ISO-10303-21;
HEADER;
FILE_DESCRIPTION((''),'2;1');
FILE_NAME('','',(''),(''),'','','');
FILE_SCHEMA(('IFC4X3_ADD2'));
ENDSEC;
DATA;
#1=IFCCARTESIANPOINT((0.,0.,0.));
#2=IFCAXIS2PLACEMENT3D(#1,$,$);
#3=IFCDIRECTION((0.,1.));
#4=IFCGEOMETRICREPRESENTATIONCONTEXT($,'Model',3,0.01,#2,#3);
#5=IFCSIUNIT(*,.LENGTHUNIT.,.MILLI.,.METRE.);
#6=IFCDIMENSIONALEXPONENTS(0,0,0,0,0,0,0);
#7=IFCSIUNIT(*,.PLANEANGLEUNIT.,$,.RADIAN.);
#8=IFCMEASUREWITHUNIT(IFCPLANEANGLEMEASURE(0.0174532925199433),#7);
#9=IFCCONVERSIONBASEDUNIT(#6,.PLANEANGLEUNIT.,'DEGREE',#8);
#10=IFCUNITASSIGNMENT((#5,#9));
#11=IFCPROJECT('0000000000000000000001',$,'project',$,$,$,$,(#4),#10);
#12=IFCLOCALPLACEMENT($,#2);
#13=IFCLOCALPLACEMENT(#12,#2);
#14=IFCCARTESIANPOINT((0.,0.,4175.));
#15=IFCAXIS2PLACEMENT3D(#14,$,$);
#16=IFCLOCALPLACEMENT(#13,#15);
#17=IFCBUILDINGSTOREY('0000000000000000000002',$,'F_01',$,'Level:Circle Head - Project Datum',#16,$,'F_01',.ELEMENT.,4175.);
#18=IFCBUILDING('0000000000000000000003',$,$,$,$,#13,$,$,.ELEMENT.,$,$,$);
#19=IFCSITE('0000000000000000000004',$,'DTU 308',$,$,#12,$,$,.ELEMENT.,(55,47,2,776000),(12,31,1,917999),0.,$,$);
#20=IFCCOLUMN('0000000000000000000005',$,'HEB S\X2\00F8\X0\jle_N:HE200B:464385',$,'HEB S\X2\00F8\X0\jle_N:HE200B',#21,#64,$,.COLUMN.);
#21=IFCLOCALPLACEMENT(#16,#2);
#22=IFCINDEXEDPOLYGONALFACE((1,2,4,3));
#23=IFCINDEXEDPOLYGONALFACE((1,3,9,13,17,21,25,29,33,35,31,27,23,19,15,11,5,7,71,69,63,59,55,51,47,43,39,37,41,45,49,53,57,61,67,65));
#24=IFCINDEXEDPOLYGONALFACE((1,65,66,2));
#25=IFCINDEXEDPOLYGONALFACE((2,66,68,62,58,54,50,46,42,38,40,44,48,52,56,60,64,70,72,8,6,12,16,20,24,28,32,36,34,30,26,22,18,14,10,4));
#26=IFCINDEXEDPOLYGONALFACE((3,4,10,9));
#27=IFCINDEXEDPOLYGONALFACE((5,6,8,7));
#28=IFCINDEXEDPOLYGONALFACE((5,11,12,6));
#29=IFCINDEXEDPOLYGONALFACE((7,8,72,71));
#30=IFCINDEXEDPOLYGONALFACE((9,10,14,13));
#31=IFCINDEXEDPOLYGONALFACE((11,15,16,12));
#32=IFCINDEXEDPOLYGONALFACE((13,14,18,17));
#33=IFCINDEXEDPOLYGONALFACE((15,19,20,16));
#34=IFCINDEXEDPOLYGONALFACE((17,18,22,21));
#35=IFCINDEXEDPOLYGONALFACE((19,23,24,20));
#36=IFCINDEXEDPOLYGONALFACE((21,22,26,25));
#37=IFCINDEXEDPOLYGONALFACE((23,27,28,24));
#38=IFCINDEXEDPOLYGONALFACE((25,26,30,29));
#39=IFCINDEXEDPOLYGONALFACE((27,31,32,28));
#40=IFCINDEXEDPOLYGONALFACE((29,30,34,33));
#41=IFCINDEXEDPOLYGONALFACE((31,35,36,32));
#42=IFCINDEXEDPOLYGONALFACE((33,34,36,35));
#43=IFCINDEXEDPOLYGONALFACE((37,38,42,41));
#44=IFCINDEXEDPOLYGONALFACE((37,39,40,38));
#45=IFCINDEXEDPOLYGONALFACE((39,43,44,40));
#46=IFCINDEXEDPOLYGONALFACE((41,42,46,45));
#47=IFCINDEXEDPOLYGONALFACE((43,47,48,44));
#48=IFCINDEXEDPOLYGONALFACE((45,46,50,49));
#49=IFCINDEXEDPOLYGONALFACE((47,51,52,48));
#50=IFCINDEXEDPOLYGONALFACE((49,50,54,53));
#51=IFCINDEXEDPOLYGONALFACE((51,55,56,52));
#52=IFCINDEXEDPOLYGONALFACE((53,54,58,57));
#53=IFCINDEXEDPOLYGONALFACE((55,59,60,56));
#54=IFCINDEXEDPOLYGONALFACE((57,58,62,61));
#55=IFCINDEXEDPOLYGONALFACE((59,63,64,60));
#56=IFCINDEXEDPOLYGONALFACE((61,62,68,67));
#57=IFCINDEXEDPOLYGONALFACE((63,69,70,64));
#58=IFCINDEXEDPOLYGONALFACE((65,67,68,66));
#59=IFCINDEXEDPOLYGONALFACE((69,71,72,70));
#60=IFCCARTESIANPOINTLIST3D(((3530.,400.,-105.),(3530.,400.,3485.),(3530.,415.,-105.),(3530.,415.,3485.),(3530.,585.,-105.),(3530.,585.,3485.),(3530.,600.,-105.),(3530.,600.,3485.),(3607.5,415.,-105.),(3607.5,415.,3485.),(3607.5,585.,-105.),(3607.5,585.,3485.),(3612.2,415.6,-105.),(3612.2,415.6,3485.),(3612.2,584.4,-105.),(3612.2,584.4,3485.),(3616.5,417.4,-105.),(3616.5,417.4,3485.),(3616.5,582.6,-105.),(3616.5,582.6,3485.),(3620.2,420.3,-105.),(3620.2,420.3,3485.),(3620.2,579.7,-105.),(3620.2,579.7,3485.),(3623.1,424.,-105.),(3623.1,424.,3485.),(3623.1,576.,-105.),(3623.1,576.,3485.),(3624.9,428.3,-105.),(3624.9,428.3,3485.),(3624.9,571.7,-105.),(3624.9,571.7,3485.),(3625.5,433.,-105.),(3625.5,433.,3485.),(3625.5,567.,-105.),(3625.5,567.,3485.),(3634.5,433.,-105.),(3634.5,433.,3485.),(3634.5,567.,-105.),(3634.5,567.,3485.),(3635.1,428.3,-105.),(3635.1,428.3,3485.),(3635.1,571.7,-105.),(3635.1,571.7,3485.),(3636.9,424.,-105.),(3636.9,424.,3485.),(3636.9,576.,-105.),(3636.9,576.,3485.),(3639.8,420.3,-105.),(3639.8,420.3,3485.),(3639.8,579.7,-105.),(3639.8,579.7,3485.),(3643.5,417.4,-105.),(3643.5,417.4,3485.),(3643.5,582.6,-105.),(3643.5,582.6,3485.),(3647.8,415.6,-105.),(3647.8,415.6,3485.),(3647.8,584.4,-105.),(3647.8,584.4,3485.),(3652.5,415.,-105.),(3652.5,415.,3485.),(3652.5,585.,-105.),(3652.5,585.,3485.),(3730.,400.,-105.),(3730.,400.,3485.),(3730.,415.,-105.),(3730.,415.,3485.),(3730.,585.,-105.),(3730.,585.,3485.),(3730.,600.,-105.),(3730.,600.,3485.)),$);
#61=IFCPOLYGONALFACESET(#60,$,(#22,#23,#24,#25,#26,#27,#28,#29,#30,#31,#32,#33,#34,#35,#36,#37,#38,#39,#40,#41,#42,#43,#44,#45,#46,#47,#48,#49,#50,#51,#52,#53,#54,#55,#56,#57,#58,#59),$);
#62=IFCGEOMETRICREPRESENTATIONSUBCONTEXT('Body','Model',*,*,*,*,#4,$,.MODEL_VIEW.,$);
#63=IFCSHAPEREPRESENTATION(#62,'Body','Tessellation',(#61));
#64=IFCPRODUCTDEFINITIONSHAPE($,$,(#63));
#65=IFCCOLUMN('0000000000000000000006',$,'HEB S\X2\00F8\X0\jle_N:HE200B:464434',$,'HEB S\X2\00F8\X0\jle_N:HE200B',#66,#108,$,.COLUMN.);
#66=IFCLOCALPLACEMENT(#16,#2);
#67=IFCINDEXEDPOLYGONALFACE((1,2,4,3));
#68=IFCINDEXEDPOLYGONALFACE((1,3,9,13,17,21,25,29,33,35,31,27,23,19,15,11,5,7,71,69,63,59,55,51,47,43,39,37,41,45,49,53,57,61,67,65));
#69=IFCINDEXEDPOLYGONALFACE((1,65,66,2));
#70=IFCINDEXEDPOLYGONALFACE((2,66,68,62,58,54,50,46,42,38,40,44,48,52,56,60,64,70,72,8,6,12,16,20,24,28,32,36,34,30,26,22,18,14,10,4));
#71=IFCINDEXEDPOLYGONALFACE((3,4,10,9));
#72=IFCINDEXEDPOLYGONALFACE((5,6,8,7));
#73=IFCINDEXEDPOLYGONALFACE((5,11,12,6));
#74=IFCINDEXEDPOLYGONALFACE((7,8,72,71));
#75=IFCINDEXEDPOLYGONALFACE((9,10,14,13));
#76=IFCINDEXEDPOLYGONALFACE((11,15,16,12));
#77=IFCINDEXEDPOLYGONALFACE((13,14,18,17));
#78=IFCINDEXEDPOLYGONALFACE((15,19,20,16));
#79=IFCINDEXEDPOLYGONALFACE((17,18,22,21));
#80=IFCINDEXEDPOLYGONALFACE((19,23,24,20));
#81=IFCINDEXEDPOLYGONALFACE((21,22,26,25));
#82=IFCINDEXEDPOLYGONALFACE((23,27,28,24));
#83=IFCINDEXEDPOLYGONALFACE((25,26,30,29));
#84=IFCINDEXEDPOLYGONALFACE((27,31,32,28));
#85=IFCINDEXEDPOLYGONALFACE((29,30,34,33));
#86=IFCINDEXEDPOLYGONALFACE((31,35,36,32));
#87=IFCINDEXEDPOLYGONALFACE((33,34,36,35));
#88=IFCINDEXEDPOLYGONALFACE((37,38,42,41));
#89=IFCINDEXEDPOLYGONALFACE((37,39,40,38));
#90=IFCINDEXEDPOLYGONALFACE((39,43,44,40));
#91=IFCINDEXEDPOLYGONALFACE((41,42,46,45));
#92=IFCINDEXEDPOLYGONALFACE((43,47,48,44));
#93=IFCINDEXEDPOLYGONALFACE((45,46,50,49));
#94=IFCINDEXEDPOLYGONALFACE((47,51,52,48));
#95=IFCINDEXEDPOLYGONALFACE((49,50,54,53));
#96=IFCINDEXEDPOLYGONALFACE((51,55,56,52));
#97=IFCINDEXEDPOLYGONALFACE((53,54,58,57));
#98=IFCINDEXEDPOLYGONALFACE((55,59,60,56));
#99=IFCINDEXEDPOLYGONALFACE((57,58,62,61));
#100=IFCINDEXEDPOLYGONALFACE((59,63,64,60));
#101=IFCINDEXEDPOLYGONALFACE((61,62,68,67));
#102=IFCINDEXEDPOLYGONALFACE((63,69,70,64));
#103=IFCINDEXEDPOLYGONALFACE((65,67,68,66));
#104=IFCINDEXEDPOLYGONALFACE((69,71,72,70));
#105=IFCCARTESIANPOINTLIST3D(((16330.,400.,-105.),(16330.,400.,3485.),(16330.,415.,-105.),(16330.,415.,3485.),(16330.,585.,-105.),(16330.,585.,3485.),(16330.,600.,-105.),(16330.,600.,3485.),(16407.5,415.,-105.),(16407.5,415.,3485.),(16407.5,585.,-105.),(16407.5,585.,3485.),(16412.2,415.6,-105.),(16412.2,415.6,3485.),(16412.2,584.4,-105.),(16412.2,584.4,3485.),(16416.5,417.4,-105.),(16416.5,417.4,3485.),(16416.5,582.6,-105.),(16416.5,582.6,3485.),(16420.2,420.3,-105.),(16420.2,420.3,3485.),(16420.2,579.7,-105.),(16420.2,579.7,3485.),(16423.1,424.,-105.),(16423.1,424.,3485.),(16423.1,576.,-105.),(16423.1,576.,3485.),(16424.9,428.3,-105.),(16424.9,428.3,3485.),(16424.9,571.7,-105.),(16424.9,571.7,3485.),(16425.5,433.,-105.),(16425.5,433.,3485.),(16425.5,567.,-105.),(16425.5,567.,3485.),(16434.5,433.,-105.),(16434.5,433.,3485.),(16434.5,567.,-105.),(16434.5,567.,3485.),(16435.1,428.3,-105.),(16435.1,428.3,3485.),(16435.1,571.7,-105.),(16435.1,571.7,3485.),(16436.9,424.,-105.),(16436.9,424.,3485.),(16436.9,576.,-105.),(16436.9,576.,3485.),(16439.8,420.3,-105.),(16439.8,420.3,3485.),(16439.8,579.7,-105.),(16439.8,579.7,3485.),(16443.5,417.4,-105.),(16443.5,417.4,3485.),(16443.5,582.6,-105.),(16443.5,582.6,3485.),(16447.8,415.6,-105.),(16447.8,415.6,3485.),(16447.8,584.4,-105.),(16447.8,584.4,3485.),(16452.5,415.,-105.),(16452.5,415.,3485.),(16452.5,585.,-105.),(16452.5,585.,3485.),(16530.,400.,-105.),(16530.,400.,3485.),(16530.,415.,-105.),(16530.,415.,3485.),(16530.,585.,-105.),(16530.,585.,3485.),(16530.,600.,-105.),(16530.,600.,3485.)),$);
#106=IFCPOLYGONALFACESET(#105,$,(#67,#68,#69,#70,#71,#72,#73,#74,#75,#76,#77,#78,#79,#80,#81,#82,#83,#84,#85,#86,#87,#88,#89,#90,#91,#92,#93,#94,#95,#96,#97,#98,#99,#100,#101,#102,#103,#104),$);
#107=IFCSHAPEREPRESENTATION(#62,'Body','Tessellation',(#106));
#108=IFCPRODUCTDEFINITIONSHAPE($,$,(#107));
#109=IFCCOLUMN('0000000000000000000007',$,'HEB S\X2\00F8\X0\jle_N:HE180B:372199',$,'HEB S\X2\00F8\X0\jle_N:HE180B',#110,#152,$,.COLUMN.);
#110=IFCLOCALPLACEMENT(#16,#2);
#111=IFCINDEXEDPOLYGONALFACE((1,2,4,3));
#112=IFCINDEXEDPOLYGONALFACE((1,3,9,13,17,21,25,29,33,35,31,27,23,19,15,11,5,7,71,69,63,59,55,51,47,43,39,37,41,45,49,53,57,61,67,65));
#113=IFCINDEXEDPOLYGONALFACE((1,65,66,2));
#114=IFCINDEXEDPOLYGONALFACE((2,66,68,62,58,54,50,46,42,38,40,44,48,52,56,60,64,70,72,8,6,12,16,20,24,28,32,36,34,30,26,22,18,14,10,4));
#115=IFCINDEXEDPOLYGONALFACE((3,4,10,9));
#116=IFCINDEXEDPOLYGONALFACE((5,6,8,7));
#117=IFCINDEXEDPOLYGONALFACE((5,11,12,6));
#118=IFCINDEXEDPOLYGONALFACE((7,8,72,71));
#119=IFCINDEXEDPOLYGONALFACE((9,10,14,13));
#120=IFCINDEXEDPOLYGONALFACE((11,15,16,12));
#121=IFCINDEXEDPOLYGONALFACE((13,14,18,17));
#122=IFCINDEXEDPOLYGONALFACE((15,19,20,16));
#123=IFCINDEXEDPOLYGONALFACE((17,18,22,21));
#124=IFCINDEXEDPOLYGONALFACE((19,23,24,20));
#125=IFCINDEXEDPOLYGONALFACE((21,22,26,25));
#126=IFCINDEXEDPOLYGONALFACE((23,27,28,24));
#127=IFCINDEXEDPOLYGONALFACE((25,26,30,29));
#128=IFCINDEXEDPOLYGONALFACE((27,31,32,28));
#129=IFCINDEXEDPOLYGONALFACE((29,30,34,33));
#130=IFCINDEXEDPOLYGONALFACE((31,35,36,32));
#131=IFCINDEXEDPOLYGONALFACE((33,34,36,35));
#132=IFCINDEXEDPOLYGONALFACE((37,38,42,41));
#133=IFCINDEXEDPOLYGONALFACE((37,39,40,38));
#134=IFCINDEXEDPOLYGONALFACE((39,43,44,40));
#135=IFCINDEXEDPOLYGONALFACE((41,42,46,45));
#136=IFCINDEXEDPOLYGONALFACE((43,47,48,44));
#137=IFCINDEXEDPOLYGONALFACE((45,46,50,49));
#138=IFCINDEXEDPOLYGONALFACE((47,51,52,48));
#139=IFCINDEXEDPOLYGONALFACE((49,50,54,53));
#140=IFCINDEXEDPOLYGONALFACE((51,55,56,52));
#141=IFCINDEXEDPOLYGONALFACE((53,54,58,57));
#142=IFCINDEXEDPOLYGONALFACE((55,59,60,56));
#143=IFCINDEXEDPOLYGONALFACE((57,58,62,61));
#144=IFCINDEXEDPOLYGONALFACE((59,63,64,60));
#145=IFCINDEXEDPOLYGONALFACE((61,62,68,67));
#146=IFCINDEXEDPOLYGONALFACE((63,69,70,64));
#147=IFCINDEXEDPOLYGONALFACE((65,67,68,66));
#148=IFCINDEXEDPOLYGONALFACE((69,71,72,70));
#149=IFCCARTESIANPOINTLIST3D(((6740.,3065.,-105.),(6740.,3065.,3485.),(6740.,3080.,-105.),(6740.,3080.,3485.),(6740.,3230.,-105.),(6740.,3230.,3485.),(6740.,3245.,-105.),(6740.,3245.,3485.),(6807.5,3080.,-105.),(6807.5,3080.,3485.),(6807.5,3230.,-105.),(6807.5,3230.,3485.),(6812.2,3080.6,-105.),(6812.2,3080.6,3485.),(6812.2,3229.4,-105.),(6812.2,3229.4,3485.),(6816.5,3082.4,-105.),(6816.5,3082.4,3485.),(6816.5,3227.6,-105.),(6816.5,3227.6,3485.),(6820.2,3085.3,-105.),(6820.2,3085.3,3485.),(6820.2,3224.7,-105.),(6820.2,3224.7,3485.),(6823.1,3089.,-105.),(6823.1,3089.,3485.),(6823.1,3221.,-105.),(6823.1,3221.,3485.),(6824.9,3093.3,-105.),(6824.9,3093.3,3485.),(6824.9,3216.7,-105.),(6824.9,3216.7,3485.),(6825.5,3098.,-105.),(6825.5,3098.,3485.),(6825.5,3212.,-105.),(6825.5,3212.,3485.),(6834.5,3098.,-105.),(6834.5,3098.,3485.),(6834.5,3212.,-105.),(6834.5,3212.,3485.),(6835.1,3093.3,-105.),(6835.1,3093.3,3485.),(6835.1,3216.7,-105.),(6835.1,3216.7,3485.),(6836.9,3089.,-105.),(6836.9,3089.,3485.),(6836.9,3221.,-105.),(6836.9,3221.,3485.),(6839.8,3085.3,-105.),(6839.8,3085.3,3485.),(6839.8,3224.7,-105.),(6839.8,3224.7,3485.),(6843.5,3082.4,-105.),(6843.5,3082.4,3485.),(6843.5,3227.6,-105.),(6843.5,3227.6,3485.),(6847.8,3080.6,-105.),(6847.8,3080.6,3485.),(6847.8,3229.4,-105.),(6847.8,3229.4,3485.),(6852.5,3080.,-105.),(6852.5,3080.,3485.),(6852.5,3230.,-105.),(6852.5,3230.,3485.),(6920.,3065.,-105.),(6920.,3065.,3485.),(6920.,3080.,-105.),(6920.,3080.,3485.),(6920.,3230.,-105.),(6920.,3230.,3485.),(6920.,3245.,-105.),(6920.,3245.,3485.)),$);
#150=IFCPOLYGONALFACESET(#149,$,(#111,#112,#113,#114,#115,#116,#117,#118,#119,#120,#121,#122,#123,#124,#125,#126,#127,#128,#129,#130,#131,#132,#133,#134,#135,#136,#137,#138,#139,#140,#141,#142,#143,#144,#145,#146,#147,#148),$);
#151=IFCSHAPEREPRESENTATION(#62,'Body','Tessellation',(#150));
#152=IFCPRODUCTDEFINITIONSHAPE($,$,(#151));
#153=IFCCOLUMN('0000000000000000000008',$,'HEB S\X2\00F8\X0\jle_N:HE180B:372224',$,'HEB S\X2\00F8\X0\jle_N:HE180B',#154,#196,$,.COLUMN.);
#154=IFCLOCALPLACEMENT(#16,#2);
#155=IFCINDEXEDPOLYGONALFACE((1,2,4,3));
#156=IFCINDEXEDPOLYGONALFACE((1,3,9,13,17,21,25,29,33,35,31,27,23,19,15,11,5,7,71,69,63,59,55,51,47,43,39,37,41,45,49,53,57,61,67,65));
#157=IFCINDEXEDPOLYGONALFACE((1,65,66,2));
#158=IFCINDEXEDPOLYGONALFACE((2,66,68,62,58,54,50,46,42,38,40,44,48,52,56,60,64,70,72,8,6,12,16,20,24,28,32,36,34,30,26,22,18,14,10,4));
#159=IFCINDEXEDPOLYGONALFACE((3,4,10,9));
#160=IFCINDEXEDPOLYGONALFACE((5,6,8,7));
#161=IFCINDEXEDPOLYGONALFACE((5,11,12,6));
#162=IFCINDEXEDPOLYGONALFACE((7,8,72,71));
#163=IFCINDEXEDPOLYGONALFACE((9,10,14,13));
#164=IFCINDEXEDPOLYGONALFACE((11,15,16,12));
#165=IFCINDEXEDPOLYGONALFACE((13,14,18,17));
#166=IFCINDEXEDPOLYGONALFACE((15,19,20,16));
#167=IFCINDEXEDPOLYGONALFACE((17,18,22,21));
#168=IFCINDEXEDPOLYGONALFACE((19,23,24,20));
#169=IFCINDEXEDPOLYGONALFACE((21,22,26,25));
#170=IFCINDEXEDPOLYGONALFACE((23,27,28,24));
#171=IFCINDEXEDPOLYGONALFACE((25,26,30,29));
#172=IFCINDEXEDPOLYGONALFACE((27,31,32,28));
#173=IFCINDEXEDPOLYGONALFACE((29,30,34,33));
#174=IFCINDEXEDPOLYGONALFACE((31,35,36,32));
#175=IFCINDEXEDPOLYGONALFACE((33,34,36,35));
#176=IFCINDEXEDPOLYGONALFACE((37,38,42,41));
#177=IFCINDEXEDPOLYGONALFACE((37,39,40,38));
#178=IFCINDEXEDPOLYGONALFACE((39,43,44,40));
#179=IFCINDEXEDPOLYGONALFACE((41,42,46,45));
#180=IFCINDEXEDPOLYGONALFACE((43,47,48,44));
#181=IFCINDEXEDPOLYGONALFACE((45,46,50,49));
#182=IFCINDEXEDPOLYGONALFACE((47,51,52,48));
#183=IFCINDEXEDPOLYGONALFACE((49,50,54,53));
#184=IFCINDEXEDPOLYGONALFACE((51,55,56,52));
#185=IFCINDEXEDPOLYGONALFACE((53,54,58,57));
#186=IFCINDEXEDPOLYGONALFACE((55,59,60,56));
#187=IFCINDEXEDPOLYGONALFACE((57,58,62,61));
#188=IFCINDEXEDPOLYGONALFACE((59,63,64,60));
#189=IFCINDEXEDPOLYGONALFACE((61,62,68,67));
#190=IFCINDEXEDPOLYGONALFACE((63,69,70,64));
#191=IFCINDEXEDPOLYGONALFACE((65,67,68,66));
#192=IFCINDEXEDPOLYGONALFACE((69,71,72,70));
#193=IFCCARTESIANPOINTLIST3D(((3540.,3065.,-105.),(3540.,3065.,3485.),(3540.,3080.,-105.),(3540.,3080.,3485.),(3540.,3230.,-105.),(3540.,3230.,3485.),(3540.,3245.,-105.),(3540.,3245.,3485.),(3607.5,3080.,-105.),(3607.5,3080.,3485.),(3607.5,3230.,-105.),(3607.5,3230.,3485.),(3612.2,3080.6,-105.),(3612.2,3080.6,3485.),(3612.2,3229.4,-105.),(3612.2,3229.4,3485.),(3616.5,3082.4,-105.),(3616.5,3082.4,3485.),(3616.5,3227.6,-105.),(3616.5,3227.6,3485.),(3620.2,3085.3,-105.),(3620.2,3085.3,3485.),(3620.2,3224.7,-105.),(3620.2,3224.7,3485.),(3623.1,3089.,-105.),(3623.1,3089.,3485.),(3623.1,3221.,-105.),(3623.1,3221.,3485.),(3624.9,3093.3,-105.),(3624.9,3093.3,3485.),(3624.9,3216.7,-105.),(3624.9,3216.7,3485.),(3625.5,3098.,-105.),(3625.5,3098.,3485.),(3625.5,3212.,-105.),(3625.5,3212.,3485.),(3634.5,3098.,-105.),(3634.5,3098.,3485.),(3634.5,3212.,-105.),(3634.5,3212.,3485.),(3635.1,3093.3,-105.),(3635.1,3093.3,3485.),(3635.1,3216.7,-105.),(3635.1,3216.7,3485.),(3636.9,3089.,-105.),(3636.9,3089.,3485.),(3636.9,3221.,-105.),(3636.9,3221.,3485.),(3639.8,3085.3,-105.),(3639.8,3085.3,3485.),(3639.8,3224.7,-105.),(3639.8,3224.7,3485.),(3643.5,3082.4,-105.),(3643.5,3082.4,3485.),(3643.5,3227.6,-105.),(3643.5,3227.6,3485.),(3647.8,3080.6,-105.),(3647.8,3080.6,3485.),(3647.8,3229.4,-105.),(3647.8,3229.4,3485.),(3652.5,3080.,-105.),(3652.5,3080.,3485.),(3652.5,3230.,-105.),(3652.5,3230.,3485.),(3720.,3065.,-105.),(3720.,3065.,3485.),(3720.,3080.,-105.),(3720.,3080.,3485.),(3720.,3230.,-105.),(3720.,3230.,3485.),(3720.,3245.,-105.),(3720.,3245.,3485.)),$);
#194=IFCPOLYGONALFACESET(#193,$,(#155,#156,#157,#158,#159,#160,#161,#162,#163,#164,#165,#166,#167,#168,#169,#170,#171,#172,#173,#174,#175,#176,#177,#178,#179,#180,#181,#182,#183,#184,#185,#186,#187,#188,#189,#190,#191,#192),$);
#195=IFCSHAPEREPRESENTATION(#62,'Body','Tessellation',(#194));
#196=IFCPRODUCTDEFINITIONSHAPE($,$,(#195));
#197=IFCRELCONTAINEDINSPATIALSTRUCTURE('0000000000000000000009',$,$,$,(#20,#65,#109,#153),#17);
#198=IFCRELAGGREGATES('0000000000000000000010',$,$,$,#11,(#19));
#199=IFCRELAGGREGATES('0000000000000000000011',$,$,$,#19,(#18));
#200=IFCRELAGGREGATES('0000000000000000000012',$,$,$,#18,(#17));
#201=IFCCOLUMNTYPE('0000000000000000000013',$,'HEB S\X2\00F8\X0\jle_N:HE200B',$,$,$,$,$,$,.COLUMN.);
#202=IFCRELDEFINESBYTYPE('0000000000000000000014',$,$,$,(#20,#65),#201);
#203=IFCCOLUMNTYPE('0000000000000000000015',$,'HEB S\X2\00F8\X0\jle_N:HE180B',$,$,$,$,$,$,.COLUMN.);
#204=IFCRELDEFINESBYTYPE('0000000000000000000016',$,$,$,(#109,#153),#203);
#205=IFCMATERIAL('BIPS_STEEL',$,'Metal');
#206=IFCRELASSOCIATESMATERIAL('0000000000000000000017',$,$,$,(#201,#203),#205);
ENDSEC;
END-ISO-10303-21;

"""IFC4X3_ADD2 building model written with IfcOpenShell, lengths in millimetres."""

from ifc_helpers import new_model, entity, si_unit, converted_unit, direction, frame, frame_2d, origin, place, context, subcontext, project, spatial, i_section, extrude, source, transform, mapped, material, material_profile, profile_set, type_object, type_shapes, element, save


model = new_model("IFC4X3_ADD2")

# Units and contexts
model_context = context("Model", 3, precision=0.01, world=origin(), true_north=direction((0.0, 1.0)))
body_context = subcontext(model_context, "Body", "Model", "MODEL_VIEW")
ifc_project = project(units=[si_unit("LENGTHUNIT", "METRE", prefix="MILLI"), converted_unit("PLANEANGLEUNIT", "DEGREE", entity("IfcPlaneAngleMeasure", 0.0174532925199433), si_unit("PLANEANGLEUNIT", "RADIAN"), dimensions=[0, 0, 0, 0, 0, 0, 0])], contexts=[model_context])

# Site, building, storey
site_placement = place(None, origin())
site = spatial("IfcSite", under=ifc_project, at=site_placement, Name="DTU 308", CompositionType="ELEMENT", RefLatitude=(55, 47, 2, 776000), RefLongitude=(12, 31, 1, 917999), RefElevation=0.0)
building_placement = place(site_placement, origin())
building = spatial("IfcBuilding", under=site, at=building_placement, CompositionType="ELEMENT")
storey_placement = place(building_placement, frame((0.0, 0.0, 4175.0)))
storey = spatial("IfcBuildingStorey", under=building, at=storey_placement, Name="F_01", ObjectType="Level:Circle Head - Project Datum", LongName="F_01", CompositionType="ELEMENT", Elevation=4175.0)

# Columns
ifc_material_1 = material(Name="BIPS_STEEL", Category="Metal")
ifc_material_profile_1 = material_profile(ifc_material_1, i_section(OverallWidth=200.0, OverallDepth=200.0, WebThickness=9.0, FlangeThickness=15.0, FilletRadius=18.0, at=frame_2d((0.0, 0.0), x_axis=(1.0, 0.0))), Name="HE200B")
ifc_profile_set_1 = profile_set([ifc_material_profile_1], Name="HE200B")
column_type_1 = type_object("IfcColumnType", Name="HEB Søjle_N:HE200B", PredefinedType="COLUMN", material=ifc_profile_set_1)
shared_shape_1 = source(origin(), body_context, "Body", "SweptSolid", [
    extrude(i_section(OverallWidth=200.0, OverallDepth=200.0, WebThickness=9.0, FlangeThickness=15.0, FilletRadius=18.0, at=frame_2d((0.0, 0.0), x_axis=(1.0, 0.0))), frame((0.0, 0.0, 4070.0), z_axis=(0.0, 0.0, 1.0), x_axis=(-1.0, 0.0, 0.0)), (0.0, 0.0, 1.0), 3590.0),
])
type_shapes(column_type_1, [shared_shape_1])
for number, where, name in (
    (1, (3630.0, 500.0, -4175.0), "HEB Søjle_N:HE200B:464385"),
    (2, (16430.0, 500.0, -4175.0), "HEB Søjle_N:HE200B:464434"),
):
    element("IfcColumn", number, at=place(storey_placement, frame(where)), inside=storey, type_object=column_type_1, Name=name, ObjectType="HEB Søjle_N:HE200B", PredefinedType="COLUMN", context=body_context, shape_type="MappedRepresentation", body=[
        mapped(shared_shape_1, transform((0.0, 0.0, 0.0), scale=1.0)),
    ])
ifc_material_profile_2 = material_profile(ifc_material_1, i_section(OverallWidth=180.0, OverallDepth=180.0, WebThickness=9.0, FlangeThickness=15.0, FilletRadius=18.0, at=frame_2d((0.0, 0.0), x_axis=(1.0, 0.0))), Name="HE180B")
ifc_profile_set_2 = profile_set([ifc_material_profile_2], Name="HE180B")
column_type_2 = type_object("IfcColumnType", Name="HEB Søjle_N:HE180B", PredefinedType="COLUMN", material=ifc_profile_set_2)
shared_shape_2 = source(origin(), body_context, "Body", "SweptSolid", [
    extrude(i_section(OverallWidth=180.0, OverallDepth=180.0, WebThickness=9.0, FlangeThickness=15.0, FilletRadius=18.0, at=frame_2d((0.0, 0.0), x_axis=(1.0, 0.0))), frame((0.0, 0.0, 4070.0), z_axis=(0.0, 0.0, 1.0), x_axis=(-1.0, 0.0, 0.0)), (0.0, 0.0, 1.0), 3590.0),
])
type_shapes(column_type_2, [shared_shape_2])
for number, where, name in (
    (3, (6830.0, 3155.0, -4175.0), "HEB Søjle_N:HE180B:372199"),
    (4, (3630.0, 3155.0, -4175.0), "HEB Søjle_N:HE180B:372224"),
):
    element("IfcColumn", number, at=place(storey_placement, frame(where)), inside=storey, type_object=column_type_2, Name=name, ObjectType="HEB Søjle_N:HE180B", PredefinedType="COLUMN", context=body_context, shape_type="MappedRepresentation", body=[
        mapped(shared_shape_2, transform((0.0, 0.0, 0.0), scale=1.0)),
    ])

save(model, "model.ifc")
